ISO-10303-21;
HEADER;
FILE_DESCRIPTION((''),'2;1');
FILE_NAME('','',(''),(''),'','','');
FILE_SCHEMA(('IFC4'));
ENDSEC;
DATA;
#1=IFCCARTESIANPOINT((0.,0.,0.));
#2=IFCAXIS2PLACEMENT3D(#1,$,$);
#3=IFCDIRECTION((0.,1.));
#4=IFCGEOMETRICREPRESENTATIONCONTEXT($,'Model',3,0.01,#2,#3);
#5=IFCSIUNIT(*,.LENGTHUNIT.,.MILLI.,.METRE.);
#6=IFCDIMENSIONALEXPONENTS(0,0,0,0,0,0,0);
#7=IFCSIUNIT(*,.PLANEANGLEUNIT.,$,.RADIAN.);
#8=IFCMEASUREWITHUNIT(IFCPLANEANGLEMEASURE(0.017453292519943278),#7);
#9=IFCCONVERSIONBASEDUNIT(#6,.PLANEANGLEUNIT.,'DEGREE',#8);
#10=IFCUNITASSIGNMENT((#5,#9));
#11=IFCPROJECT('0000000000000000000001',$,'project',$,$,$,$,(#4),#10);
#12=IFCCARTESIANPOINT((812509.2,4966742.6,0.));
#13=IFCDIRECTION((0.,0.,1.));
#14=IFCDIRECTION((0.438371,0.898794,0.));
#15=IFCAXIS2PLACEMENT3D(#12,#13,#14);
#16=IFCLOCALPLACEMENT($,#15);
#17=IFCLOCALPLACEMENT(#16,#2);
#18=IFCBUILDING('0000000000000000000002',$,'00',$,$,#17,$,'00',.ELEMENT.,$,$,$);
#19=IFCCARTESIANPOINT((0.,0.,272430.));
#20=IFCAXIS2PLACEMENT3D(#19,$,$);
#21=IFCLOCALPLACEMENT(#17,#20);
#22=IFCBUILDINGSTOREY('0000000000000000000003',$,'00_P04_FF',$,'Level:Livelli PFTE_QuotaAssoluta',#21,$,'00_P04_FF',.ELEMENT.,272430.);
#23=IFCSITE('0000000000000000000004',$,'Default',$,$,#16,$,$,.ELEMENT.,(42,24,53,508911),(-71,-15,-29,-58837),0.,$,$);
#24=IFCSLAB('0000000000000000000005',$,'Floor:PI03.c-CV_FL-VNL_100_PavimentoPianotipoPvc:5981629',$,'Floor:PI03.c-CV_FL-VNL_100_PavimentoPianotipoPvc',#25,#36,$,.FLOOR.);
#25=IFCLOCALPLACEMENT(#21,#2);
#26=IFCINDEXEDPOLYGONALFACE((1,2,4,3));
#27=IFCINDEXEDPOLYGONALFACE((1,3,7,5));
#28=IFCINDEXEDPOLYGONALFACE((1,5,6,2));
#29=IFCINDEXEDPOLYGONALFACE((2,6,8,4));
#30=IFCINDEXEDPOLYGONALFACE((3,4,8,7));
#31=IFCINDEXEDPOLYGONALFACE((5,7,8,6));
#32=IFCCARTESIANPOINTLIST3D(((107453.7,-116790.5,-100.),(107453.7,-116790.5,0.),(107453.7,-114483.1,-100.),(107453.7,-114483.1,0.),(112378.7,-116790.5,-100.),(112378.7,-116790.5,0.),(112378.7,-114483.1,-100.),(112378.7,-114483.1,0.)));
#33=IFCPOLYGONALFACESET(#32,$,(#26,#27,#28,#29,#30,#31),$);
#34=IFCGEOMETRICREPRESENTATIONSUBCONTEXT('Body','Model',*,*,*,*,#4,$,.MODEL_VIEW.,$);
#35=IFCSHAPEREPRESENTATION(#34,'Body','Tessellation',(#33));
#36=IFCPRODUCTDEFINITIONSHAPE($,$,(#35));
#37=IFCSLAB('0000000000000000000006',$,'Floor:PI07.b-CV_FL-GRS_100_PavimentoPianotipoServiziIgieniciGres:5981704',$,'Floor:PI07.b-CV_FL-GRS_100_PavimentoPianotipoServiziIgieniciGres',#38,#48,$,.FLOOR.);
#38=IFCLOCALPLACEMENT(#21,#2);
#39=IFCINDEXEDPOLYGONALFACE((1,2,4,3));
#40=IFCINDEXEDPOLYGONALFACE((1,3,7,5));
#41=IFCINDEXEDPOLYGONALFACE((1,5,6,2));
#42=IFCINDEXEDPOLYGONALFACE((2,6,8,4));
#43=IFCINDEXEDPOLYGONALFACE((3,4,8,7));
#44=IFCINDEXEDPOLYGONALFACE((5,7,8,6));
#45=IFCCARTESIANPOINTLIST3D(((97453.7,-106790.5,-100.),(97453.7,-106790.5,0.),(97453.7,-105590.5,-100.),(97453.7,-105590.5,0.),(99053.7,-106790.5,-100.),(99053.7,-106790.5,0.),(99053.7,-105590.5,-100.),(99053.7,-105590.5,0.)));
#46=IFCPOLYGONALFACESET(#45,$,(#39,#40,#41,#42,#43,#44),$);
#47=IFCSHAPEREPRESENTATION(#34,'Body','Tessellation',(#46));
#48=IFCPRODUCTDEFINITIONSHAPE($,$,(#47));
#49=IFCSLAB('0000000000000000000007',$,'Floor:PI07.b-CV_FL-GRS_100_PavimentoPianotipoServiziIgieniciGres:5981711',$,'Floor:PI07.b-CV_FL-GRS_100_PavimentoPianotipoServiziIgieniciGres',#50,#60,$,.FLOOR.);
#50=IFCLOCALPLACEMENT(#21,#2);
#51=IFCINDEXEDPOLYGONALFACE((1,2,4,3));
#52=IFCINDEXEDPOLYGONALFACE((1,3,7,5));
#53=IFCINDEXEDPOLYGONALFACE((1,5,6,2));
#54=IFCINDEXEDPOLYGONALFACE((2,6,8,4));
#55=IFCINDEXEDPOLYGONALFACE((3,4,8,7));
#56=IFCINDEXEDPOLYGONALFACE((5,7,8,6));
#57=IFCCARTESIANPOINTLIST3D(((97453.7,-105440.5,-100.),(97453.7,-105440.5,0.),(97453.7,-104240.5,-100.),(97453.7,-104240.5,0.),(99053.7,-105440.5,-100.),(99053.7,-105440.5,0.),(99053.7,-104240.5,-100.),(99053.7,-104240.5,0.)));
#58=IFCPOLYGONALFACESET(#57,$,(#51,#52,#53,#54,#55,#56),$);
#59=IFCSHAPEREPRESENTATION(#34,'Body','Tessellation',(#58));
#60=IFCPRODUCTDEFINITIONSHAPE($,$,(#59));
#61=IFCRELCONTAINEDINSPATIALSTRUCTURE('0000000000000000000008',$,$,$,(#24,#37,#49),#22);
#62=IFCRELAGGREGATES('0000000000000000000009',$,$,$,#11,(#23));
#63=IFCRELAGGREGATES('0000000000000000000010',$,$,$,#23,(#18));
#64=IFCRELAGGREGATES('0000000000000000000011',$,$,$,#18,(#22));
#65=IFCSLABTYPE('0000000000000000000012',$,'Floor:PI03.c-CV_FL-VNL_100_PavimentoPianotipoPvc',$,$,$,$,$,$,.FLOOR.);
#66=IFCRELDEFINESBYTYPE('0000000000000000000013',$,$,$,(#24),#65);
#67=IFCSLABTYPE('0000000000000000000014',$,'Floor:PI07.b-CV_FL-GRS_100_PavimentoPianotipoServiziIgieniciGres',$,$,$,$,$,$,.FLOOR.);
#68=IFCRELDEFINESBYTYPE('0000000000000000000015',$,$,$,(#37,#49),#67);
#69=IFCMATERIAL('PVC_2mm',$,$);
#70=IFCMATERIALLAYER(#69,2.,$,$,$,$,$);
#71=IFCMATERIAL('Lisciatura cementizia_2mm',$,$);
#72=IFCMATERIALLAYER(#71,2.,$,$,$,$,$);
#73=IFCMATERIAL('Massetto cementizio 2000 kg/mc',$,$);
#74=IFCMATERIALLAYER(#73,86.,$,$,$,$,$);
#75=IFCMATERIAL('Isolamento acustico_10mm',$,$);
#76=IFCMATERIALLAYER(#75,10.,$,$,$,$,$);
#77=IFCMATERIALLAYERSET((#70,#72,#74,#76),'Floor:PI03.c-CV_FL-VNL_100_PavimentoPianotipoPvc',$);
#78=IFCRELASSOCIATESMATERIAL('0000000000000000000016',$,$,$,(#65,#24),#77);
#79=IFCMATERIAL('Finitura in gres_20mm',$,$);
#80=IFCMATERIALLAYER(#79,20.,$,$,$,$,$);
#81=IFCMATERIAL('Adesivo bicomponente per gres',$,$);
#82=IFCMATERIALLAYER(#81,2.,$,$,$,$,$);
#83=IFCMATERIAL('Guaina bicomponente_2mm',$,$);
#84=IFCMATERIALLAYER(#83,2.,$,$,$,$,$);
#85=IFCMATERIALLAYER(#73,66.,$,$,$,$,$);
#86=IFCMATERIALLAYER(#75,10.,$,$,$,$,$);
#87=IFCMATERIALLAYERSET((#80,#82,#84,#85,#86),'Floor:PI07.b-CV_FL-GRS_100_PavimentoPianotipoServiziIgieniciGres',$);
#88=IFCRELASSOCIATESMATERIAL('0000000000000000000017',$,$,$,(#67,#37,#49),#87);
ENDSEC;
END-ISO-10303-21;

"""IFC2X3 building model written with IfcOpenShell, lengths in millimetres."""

from ifc_helpers import new_model, entity, si_unit, converted_unit, direction, frame, origin, origin_2d_with_axis, place, context, subcontext, project, spatial, rectangle, extrude, material, layer, layer_set, layer_usage, type_object, element, save


model = new_model("IFC2X3")

# Units and contexts
model_context = context("Model", 3, precision=0.01, world=origin(), true_north=direction((0.0, 1.0)))
body_context = subcontext(model_context, "Body", "Model", "MODEL_VIEW")
ifc_project = project(units=[si_unit("LENGTHUNIT", "METRE", prefix="MILLI"), converted_unit("PLANEANGLEUNIT", "DEGREE", entity("IfcPlaneAngleMeasure", 0.017453292519943278), si_unit("PLANEANGLEUNIT", "RADIAN"), dimensions=[0, 0, 0, 0, 0, 0, 0])], contexts=[model_context])

# Site, building, storey
site_placement = place(None, frame((812509.2, 4966742.6, 0.0), z_axis=(0.0, 0.0, 1.0), x_axis=(0.438371, 0.898794, 0.0)))
site = spatial("IfcSite", under=ifc_project, at=site_placement, Name="Default", CompositionType="ELEMENT", RefLatitude=(42, 24, 53, 508911), RefLongitude=(-71, -15, -29, -58837), RefElevation=0.0)
building_placement = place(site_placement, origin())
building = spatial("IfcBuilding", under=site, at=building_placement, Name="00", LongName="00", CompositionType="ELEMENT")
storey_placement = place(building_placement, frame((0.0, 0.0, 272430.0)))
storey = spatial("IfcBuildingStorey", under=building, at=storey_placement, Name="00_P04_FF", ObjectType="Level:Livelli PFTE_QuotaAssoluta", LongName="00_P04_FF", CompositionType="ELEMENT", Elevation=272430.0)

# Slabs
ifc_material_1 = material(Name="PVC_2mm")
ifc_layer_1 = layer(ifc_material_1, 2.0)
ifc_material_2 = material(Name="Lisciatura cementizia_2mm")
ifc_layer_2 = layer(ifc_material_2, 2.0)
ifc_material_3 = material(Name="Massetto cementizio 2000 kg/mc")
ifc_layer_3 = layer(ifc_material_3, 86.0)
ifc_material_4 = material(Name="Isolamento acustico_10mm")
ifc_layer_4 = layer(ifc_material_4, 10.0)
ifc_layer_set_1 = layer_set([ifc_layer_1, ifc_layer_2, ifc_layer_3, ifc_layer_4], Name="Floor:PI03.c-CV_FL-VNL_100_PavimentoPianotipoPvc")
ifc_layer_usage_1 = layer_usage(ifc_layer_set_1, "AXIS3", "POSITIVE", 0.0)
slab_type_1 = type_object("IfcSlabType", Name="Floor:PI03.c-CV_FL-VNL_100_PavimentoPianotipoPvc", PredefinedType="FLOOR", material=ifc_layer_set_1)
slab_1_placement = place(storey_placement, origin())
element("IfcSlab", 1, at=slab_1_placement, inside=storey, type_object=slab_type_1, material=ifc_layer_usage_1, Name="Floor:PI03.c-CV_FL-VNL_100_PavimentoPianotipoPvc:5981629", ObjectType="Floor:PI03.c-CV_FL-VNL_100_PavimentoPianotipoPvc", PredefinedType="FLOOR", context=body_context, shape_type="SweptSolid", body=[
    extrude(rectangle(XDim=2307.4, YDim=4925.0, at=origin_2d_with_axis()), frame((109916.2, -115636.8, 0.0), z_axis=(0.0, 0.0, -1.0), x_axis=(0.0, 1.0, 0.0)), (0.0, 0.0, 1.0), 100.0),
])
ifc_material_5 = material(Name="Finitura in gres_20mm")
ifc_layer_5 = layer(ifc_material_5, 20.0)
ifc_material_6 = material(Name="Adesivo bicomponente per gres")
ifc_layer_6 = layer(ifc_material_6, 2.0)
ifc_material_7 = material(Name="Guaina bicomponente_2mm")
ifc_layer_7 = layer(ifc_material_7, 2.0)
ifc_layer_8 = layer(ifc_material_3, 66.0)
ifc_layer_9 = layer(ifc_material_4, 10.0)
ifc_layer_set_2 = layer_set([ifc_layer_5, ifc_layer_6, ifc_layer_7, ifc_layer_8, ifc_layer_9], Name="Floor:PI07.b-CV_FL-GRS_100_PavimentoPianotipoServiziIgieniciGres")
slab_type_2 = type_object("IfcSlabType", Name="Floor:PI07.b-CV_FL-GRS_100_PavimentoPianotipoServiziIgieniciGres", PredefinedType="FLOOR", material=ifc_layer_set_2)
ifc_layer_usage_2 = layer_usage(ifc_layer_set_2, "AXIS3", "POSITIVE", 0.0)
slab_2_placement = place(storey_placement, origin())
element("IfcSlab", 2, at=slab_2_placement, inside=storey, type_object=slab_type_2, material=ifc_layer_usage_2, Name="Floor:PI07.b-CV_FL-GRS_100_PavimentoPianotipoServiziIgieniciGres:5981704", ObjectType="Floor:PI07.b-CV_FL-GRS_100_PavimentoPianotipoServiziIgieniciGres", PredefinedType="FLOOR", context=body_context, shape_type="SweptSolid", body=[
    extrude(rectangle(XDim=1200.0, YDim=1600.0, at=origin_2d_with_axis()), frame((98253.7, -106190.5, 0.0), z_axis=(0.0, 0.0, -1.0), x_axis=(0.0, 1.0, 0.0)), (0.0, 0.0, 1.0), 100.0),
])
ifc_layer_usage_3 = layer_usage(ifc_layer_set_2, "AXIS3", "POSITIVE", 0.0)
slab_3_placement = place(storey_placement, origin())
element("IfcSlab", 3, at=slab_3_placement, inside=storey, type_object=slab_type_2, material=ifc_layer_usage_3, Name="Floor:PI07.b-CV_FL-GRS_100_PavimentoPianotipoServiziIgieniciGres:5981711", ObjectType="Floor:PI07.b-CV_FL-GRS_100_PavimentoPianotipoServiziIgieniciGres", PredefinedType="FLOOR", context=body_context, shape_type="SweptSolid", body=[
    extrude(rectangle(XDim=1200.0, YDim=1600.0, at=origin_2d_with_axis()), frame((98253.7, -104840.5, 0.0), z_axis=(0.0, 0.0, -1.0), x_axis=(0.0, 1.0, 0.0)), (0.0, 0.0, 1.0), 100.0),
])

save(model, "model.ifc")
